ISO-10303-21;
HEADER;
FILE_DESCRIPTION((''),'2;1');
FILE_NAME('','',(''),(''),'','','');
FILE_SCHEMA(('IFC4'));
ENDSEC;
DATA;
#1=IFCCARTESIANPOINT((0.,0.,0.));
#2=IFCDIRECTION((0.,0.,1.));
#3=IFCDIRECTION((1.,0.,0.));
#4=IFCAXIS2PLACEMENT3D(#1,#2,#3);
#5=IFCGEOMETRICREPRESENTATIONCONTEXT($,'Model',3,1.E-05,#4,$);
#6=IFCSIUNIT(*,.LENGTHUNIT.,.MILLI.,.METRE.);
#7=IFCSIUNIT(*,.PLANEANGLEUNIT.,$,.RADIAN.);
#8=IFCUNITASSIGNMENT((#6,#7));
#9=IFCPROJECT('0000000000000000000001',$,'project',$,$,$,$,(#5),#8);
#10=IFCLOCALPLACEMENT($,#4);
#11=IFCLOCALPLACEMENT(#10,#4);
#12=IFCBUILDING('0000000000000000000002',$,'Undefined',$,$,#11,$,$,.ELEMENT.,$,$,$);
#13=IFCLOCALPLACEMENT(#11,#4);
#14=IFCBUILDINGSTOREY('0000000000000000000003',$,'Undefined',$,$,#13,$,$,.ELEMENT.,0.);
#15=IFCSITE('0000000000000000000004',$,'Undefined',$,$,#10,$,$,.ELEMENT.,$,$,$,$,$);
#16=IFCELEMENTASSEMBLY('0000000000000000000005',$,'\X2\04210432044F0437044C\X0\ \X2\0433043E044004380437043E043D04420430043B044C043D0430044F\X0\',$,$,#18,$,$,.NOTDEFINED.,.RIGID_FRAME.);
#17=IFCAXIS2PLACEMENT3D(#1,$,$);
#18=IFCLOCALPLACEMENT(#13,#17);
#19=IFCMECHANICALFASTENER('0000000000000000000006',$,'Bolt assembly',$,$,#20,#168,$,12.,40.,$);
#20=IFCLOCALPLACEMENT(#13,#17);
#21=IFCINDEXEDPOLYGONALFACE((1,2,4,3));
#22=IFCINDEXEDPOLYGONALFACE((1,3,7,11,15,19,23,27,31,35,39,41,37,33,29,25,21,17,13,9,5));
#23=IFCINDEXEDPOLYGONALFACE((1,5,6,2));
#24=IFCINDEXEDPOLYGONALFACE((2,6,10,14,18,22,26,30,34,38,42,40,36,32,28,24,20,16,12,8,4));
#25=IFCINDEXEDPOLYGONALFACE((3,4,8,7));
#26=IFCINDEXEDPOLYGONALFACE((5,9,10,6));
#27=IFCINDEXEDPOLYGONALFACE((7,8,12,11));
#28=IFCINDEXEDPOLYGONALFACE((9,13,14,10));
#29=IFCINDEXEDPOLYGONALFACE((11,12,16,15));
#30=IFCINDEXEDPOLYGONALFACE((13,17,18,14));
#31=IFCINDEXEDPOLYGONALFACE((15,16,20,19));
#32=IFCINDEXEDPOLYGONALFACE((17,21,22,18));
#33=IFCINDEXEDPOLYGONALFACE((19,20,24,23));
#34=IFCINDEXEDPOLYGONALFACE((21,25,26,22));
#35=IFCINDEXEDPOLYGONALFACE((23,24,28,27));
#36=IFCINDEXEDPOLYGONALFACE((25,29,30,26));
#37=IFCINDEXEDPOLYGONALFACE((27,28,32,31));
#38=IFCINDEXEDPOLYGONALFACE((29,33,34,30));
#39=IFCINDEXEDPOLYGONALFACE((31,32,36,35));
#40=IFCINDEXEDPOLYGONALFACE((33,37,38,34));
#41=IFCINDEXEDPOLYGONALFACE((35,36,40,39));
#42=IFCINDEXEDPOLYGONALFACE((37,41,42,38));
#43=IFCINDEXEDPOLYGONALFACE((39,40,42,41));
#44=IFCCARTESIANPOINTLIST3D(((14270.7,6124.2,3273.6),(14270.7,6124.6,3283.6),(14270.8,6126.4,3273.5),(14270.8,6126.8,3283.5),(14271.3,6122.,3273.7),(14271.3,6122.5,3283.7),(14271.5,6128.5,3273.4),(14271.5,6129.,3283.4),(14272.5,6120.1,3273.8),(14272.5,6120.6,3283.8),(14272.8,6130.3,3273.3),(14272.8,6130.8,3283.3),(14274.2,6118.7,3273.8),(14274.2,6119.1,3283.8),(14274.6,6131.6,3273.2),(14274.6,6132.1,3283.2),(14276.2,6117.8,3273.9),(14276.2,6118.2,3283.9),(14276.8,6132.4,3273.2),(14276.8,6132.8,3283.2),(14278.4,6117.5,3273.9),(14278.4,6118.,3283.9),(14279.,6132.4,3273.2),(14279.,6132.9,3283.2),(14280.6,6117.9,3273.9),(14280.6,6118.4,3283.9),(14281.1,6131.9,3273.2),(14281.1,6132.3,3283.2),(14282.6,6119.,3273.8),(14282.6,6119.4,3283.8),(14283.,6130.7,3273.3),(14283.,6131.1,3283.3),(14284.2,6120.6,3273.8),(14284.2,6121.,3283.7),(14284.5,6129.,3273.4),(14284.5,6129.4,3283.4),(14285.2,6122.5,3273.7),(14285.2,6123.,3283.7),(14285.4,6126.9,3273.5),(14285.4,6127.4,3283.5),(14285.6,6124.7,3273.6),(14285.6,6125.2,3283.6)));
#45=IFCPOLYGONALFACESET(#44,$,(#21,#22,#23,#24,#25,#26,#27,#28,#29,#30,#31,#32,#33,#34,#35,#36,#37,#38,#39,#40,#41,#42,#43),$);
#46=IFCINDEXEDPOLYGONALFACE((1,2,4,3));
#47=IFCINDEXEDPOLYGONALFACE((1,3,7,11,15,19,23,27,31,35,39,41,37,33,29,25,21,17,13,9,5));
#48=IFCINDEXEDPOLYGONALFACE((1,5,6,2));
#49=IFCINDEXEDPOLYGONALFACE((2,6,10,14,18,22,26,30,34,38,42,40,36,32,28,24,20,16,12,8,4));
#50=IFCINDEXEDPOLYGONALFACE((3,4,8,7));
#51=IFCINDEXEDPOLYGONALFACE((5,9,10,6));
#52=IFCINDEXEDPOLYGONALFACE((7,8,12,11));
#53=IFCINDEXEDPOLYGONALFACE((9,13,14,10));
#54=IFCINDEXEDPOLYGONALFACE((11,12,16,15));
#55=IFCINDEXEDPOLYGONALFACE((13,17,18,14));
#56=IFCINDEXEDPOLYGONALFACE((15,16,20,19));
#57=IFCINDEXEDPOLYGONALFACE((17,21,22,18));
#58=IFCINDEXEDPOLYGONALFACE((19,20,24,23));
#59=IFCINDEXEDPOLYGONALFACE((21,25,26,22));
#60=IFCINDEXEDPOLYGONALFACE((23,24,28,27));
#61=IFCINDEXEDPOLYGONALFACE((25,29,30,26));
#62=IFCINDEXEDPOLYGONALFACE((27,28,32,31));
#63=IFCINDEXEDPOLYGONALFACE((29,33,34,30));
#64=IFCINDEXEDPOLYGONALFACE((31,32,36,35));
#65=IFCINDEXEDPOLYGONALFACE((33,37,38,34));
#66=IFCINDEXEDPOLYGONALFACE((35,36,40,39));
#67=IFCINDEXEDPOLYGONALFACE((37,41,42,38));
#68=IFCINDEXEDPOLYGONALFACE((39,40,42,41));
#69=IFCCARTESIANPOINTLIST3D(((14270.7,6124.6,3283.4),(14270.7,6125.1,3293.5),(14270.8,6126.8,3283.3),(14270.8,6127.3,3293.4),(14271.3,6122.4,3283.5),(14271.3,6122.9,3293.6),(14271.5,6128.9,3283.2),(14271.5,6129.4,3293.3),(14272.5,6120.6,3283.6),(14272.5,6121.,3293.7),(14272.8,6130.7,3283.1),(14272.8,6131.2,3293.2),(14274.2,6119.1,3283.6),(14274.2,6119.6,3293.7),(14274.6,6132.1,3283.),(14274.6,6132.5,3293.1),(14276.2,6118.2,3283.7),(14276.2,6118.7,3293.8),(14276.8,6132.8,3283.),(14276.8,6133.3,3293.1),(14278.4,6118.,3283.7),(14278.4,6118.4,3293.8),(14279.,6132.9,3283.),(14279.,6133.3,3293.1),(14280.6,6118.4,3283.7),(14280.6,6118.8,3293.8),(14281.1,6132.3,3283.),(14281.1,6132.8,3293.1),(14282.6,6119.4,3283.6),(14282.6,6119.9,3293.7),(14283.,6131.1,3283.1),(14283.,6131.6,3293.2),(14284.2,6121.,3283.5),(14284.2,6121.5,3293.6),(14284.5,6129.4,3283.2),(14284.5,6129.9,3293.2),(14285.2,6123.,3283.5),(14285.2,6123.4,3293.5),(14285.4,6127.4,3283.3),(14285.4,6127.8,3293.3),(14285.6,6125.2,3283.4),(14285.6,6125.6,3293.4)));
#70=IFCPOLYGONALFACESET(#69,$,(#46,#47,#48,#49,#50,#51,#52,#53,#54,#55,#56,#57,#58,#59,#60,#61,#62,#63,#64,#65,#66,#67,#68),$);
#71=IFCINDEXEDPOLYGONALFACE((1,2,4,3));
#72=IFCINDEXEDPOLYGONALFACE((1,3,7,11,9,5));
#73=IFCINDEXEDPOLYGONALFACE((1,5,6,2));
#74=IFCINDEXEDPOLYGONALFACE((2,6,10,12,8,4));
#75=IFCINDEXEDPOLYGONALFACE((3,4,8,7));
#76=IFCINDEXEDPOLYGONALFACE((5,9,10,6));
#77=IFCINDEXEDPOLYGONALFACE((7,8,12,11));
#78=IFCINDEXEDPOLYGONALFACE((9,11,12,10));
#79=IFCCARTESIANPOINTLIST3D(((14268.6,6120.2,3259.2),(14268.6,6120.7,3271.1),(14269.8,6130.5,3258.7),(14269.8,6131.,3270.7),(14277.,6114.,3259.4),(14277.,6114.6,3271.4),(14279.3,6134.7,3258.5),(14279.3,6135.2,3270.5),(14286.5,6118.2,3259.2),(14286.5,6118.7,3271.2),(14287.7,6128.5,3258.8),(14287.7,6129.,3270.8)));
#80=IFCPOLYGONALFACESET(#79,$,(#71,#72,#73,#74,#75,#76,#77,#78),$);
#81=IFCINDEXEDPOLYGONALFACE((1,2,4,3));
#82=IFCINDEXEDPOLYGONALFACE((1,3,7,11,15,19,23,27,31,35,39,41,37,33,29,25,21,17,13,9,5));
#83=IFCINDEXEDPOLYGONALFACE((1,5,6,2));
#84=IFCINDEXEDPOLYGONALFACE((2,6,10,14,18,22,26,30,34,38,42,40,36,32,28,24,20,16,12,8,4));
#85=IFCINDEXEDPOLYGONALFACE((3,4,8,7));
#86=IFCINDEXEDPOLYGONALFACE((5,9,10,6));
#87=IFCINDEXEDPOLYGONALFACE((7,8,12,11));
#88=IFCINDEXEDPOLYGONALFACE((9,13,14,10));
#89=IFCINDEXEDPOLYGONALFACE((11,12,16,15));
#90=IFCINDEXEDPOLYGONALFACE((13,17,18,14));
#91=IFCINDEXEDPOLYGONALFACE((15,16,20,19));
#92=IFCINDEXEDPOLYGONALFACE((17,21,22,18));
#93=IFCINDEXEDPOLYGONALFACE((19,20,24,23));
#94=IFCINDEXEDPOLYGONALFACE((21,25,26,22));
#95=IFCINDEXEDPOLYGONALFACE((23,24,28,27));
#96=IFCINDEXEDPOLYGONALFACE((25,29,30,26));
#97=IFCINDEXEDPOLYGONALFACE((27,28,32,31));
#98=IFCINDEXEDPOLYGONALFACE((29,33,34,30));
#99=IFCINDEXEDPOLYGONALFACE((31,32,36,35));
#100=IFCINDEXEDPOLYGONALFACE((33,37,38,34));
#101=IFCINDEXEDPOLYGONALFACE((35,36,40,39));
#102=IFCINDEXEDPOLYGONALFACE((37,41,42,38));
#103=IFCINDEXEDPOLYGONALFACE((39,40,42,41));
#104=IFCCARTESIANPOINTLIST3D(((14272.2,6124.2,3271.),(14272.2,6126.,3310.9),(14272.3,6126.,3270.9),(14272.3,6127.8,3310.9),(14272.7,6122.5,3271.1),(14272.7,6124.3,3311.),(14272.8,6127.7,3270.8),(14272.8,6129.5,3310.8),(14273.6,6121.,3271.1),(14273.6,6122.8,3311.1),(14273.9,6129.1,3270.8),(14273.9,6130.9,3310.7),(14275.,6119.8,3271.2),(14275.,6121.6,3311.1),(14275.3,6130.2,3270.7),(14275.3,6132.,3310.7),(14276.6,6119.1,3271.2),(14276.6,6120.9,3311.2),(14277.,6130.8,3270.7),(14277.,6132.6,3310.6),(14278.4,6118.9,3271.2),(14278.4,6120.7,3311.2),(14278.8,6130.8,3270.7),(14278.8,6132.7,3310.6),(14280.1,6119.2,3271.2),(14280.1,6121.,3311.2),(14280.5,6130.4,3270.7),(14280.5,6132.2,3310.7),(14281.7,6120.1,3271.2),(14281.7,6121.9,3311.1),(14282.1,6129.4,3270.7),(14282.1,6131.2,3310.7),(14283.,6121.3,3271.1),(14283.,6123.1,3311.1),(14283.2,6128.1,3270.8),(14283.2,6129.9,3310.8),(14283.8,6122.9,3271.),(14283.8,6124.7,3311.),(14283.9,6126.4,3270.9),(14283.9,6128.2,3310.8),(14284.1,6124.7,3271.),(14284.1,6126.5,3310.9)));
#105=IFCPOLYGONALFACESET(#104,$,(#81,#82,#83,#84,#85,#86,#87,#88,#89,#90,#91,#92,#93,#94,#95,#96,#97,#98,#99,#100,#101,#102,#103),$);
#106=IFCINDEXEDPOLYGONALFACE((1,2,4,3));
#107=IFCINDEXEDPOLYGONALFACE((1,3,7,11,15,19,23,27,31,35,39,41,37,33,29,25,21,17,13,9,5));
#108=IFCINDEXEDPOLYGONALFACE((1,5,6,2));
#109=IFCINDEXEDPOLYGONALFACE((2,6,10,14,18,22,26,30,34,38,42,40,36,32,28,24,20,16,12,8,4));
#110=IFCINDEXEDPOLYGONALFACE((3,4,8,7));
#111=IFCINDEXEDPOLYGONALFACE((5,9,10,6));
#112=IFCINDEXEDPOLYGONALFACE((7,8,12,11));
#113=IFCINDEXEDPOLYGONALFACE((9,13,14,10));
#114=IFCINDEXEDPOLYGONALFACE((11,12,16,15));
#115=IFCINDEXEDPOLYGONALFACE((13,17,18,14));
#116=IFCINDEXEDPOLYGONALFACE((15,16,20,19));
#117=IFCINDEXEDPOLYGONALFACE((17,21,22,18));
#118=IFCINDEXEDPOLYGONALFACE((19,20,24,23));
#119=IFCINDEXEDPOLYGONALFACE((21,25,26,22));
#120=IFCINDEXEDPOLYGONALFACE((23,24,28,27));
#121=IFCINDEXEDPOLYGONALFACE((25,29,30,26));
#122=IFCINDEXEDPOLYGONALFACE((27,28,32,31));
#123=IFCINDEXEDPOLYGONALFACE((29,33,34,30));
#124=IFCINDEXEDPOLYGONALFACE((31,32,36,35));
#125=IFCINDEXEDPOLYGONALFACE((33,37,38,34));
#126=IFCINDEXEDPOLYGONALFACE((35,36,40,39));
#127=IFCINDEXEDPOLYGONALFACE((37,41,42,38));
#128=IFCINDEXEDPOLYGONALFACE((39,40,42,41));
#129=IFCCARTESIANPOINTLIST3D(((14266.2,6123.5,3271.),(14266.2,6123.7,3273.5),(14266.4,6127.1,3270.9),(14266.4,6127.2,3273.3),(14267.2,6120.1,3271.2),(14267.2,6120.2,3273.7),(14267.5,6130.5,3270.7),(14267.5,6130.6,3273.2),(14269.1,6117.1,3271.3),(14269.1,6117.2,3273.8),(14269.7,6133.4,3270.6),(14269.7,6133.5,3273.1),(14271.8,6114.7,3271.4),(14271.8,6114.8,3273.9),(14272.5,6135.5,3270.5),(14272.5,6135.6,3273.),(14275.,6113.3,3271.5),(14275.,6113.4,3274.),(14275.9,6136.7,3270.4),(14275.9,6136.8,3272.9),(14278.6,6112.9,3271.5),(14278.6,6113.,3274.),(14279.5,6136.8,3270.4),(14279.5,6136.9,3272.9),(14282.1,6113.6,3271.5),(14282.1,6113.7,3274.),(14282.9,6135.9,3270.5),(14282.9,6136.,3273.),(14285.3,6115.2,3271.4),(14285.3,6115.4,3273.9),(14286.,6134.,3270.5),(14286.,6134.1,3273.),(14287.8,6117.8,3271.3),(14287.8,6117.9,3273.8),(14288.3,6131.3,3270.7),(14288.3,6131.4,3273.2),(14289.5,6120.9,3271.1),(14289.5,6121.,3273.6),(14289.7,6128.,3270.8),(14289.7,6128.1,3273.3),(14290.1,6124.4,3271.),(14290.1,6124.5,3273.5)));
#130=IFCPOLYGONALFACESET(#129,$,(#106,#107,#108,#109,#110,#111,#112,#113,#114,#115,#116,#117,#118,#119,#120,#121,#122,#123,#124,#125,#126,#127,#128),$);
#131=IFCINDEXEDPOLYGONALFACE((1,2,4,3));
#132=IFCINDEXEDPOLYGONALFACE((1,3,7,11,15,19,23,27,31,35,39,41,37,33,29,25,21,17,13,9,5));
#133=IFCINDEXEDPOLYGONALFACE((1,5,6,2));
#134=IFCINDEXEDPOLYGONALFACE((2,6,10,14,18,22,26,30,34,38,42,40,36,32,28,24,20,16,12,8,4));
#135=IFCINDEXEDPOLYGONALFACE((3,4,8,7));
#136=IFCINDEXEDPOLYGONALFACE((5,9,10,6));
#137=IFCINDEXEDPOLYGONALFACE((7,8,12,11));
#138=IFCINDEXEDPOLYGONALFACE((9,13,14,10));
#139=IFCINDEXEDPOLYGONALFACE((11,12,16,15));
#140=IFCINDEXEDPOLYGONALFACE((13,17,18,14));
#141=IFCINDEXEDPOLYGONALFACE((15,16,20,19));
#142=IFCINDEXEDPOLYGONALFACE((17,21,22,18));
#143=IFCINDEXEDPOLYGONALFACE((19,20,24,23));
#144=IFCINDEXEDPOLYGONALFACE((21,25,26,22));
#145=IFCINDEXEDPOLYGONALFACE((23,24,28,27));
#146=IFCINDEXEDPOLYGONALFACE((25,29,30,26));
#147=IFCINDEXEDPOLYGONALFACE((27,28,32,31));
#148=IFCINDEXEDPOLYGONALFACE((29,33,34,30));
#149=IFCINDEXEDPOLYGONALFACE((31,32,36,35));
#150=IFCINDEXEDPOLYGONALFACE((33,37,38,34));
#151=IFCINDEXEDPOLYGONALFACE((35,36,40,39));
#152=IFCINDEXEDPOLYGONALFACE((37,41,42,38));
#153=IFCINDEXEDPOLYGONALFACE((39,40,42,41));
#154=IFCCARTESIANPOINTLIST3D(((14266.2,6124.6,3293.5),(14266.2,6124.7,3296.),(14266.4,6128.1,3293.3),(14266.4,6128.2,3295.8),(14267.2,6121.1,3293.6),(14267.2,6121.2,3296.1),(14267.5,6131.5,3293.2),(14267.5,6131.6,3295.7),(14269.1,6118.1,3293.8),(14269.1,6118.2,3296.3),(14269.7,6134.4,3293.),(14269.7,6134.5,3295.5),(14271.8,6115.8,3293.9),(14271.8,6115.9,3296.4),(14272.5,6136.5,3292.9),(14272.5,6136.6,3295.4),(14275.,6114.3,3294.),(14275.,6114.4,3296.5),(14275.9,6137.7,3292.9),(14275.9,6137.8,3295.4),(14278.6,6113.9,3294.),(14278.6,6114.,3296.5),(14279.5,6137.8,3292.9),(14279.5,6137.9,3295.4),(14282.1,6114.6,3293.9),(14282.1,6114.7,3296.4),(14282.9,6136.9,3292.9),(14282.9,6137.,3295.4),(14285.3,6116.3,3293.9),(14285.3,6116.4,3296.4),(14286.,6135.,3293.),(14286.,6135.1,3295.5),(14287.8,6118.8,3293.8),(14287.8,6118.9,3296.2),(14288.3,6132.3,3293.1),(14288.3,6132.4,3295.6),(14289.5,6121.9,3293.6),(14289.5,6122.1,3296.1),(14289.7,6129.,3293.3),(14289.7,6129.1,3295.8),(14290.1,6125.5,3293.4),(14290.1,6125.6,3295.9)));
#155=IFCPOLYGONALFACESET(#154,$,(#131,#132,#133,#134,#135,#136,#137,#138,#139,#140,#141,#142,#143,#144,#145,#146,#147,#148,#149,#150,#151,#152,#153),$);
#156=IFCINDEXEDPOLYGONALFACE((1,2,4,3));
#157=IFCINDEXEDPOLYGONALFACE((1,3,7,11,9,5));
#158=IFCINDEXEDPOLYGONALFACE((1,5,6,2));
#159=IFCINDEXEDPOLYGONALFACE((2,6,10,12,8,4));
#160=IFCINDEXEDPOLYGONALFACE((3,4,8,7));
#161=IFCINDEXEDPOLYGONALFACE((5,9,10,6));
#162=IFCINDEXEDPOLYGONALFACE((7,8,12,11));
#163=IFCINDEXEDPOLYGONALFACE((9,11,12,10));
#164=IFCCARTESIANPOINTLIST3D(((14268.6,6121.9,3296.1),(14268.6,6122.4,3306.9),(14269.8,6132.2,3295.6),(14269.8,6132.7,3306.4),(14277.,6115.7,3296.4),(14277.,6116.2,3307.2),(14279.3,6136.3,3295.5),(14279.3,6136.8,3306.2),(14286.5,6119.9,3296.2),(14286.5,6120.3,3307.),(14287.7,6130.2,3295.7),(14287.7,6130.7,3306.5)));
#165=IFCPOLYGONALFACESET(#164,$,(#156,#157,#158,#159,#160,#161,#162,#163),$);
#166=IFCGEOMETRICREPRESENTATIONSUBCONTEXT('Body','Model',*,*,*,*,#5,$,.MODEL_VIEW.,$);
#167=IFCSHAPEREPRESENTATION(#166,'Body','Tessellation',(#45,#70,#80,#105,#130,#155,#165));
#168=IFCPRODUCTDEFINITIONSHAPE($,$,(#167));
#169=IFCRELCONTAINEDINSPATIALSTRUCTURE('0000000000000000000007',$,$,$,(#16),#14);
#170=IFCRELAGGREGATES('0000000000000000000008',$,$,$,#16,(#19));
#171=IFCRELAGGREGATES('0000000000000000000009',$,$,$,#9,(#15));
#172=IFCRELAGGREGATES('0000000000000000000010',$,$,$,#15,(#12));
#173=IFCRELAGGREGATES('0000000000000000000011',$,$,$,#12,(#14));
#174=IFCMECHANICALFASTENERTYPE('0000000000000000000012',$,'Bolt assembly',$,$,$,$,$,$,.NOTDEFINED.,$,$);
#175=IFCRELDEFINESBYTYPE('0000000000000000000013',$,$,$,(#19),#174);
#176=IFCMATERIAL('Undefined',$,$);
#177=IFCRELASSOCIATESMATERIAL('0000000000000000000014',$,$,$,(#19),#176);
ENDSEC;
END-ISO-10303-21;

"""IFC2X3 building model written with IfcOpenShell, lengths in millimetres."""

from ifc_helpers import new_model, si_unit, frame, origin_with_axes, origin_2d_with_axis, place, context, subcontext, project, spatial, polyline, circle, outline, extrude, source, transform, mapped, material, type_object, element, aggregate, save


model = new_model("IFC2X3")

# Units and contexts
model_context = context("Model", 3, precision=1e-05, world=origin_with_axes())
body_context = subcontext(model_context, "Body", "Model", "MODEL_VIEW")
ifc_project = project(units=[si_unit("LENGTHUNIT", "METRE", prefix="MILLI"), si_unit("PLANEANGLEUNIT", "RADIAN")], contexts=[model_context])

# Site, building, storey
site_placement = place(None, origin_with_axes())
site = spatial("IfcSite", under=ifc_project, at=site_placement, Name="Undefined", CompositionType="ELEMENT")
building_placement = place(site_placement, origin_with_axes())
building = spatial("IfcBuilding", under=site, at=building_placement, Name="Undefined", CompositionType="ELEMENT")
storey_placement = place(building_placement, origin_with_axes())
storey = spatial("IfcBuildingStorey", under=building, at=storey_placement, Name="Undefined", CompositionType="ELEMENT", Elevation=0.0)

# Element assembly
assembly_1_placement = place(storey_placement, origin_with_axes())
assembly_1 = element("IfcElementAssembly", 1, at=assembly_1_placement, inside=storey, Name="Связь горизонтальная", AssemblyPlace="NOTDEFINED", PredefinedType="RIGID_FRAME")

# Mechanical fastener
ifc_material_1 = material(Name="Undefined")
mechanical_fastener_type = type_object("IfcMechanicalFastenerType", Name="Bolt assembly")
shared_shape_1 = source(origin_with_axes(), body_context, "Body", "SweptSolid", [
    extrude(circle(Radius=7.5, at=origin_2d_with_axis()), frame((0.0, 0.1, 0.0), z_axis=(0.0, 1.0, 0.0), x_axis=(1.0, 0.0, 0.0)), (0.0, 0.0, 1.0), 10.0),
    extrude(circle(Radius=7.5, at=origin_2d_with_axis()), frame((0.0, 9.9, 0.0), z_axis=(0.0, 1.0, 0.0), x_axis=(1.0, 0.0, 0.0)), (0.0, 0.0, 1.0), 10.1),
    extrude(outline(polyline([(10.4, 0.0), (5.2, 9.0), (-5.2, 9.0), (-10.4, 0.0), (-5.2, -9.0), (5.2, -9.0), (10.4, 0.0)])), frame((0.0, -14.5, 0.0), z_axis=(0.0, 1.0, 0.0), x_axis=(1.0, 0.0, 0.0)), (0.0, 0.0, 1.0), 12.0),
    extrude(circle(Radius=6.0, at=origin_2d_with_axis()), frame((0.0, -2.5, 0.0), z_axis=(0.0, 1.0, 0.0), x_axis=(1.0, 0.0, 0.0)), (0.0, 0.0, 1.0), 40.0),
    extrude(circle(Radius=12.0, at=origin_2d_with_axis()), frame((0.0, -2.5, 0.0), z_axis=(0.0, 1.0, 0.0), x_axis=(1.0, 0.0, 0.0)), (0.0, 0.0, 1.0), 2.5),
    extrude(circle(Radius=12.0, at=origin_2d_with_axis()), frame((0.0, 20.0, 0.0), z_axis=(0.0, 1.0, 0.0), x_axis=(1.0, 0.0, 0.0)), (0.0, 0.0, 1.0), 2.5),
    extrude(outline(polyline([(10.4, 0.0), (5.2, 9.0), (-5.2, 9.0), (-10.4, 0.0), (-5.2, -9.0), (5.2, -9.0), (10.4, 0.0)])), frame((0.0, 22.5, 0.0), z_axis=(0.0, 1.0, 0.0), x_axis=(1.0, 0.0, 0.0)), (0.0, 0.0, 1.0), 10.8),
])
mechanical_fastener_1_placement = place(assembly_1_placement, frame((14278.1, 6125.0, 3273.4), z_axis=(-0.593795, -0.803786, 0.036536), x_axis=(0.804616, -0.593183, 0.026963)))
mechanical_fastener_1 = element("IfcMechanicalFastener", 2, at=mechanical_fastener_1_placement, type_object=mechanical_fastener_type, material=ifc_material_1, Name="Bolt assembly", NominalDiameter=12.0, NominalLength=40.0, context=body_context, shape_type="MappedRepresentation", body=[
    mapped(shared_shape_1, transform((0.0, 0.0, 0.0))),
])
aggregate(assembly_1, [mechanical_fastener_1])

save(model, "model.ifc")
